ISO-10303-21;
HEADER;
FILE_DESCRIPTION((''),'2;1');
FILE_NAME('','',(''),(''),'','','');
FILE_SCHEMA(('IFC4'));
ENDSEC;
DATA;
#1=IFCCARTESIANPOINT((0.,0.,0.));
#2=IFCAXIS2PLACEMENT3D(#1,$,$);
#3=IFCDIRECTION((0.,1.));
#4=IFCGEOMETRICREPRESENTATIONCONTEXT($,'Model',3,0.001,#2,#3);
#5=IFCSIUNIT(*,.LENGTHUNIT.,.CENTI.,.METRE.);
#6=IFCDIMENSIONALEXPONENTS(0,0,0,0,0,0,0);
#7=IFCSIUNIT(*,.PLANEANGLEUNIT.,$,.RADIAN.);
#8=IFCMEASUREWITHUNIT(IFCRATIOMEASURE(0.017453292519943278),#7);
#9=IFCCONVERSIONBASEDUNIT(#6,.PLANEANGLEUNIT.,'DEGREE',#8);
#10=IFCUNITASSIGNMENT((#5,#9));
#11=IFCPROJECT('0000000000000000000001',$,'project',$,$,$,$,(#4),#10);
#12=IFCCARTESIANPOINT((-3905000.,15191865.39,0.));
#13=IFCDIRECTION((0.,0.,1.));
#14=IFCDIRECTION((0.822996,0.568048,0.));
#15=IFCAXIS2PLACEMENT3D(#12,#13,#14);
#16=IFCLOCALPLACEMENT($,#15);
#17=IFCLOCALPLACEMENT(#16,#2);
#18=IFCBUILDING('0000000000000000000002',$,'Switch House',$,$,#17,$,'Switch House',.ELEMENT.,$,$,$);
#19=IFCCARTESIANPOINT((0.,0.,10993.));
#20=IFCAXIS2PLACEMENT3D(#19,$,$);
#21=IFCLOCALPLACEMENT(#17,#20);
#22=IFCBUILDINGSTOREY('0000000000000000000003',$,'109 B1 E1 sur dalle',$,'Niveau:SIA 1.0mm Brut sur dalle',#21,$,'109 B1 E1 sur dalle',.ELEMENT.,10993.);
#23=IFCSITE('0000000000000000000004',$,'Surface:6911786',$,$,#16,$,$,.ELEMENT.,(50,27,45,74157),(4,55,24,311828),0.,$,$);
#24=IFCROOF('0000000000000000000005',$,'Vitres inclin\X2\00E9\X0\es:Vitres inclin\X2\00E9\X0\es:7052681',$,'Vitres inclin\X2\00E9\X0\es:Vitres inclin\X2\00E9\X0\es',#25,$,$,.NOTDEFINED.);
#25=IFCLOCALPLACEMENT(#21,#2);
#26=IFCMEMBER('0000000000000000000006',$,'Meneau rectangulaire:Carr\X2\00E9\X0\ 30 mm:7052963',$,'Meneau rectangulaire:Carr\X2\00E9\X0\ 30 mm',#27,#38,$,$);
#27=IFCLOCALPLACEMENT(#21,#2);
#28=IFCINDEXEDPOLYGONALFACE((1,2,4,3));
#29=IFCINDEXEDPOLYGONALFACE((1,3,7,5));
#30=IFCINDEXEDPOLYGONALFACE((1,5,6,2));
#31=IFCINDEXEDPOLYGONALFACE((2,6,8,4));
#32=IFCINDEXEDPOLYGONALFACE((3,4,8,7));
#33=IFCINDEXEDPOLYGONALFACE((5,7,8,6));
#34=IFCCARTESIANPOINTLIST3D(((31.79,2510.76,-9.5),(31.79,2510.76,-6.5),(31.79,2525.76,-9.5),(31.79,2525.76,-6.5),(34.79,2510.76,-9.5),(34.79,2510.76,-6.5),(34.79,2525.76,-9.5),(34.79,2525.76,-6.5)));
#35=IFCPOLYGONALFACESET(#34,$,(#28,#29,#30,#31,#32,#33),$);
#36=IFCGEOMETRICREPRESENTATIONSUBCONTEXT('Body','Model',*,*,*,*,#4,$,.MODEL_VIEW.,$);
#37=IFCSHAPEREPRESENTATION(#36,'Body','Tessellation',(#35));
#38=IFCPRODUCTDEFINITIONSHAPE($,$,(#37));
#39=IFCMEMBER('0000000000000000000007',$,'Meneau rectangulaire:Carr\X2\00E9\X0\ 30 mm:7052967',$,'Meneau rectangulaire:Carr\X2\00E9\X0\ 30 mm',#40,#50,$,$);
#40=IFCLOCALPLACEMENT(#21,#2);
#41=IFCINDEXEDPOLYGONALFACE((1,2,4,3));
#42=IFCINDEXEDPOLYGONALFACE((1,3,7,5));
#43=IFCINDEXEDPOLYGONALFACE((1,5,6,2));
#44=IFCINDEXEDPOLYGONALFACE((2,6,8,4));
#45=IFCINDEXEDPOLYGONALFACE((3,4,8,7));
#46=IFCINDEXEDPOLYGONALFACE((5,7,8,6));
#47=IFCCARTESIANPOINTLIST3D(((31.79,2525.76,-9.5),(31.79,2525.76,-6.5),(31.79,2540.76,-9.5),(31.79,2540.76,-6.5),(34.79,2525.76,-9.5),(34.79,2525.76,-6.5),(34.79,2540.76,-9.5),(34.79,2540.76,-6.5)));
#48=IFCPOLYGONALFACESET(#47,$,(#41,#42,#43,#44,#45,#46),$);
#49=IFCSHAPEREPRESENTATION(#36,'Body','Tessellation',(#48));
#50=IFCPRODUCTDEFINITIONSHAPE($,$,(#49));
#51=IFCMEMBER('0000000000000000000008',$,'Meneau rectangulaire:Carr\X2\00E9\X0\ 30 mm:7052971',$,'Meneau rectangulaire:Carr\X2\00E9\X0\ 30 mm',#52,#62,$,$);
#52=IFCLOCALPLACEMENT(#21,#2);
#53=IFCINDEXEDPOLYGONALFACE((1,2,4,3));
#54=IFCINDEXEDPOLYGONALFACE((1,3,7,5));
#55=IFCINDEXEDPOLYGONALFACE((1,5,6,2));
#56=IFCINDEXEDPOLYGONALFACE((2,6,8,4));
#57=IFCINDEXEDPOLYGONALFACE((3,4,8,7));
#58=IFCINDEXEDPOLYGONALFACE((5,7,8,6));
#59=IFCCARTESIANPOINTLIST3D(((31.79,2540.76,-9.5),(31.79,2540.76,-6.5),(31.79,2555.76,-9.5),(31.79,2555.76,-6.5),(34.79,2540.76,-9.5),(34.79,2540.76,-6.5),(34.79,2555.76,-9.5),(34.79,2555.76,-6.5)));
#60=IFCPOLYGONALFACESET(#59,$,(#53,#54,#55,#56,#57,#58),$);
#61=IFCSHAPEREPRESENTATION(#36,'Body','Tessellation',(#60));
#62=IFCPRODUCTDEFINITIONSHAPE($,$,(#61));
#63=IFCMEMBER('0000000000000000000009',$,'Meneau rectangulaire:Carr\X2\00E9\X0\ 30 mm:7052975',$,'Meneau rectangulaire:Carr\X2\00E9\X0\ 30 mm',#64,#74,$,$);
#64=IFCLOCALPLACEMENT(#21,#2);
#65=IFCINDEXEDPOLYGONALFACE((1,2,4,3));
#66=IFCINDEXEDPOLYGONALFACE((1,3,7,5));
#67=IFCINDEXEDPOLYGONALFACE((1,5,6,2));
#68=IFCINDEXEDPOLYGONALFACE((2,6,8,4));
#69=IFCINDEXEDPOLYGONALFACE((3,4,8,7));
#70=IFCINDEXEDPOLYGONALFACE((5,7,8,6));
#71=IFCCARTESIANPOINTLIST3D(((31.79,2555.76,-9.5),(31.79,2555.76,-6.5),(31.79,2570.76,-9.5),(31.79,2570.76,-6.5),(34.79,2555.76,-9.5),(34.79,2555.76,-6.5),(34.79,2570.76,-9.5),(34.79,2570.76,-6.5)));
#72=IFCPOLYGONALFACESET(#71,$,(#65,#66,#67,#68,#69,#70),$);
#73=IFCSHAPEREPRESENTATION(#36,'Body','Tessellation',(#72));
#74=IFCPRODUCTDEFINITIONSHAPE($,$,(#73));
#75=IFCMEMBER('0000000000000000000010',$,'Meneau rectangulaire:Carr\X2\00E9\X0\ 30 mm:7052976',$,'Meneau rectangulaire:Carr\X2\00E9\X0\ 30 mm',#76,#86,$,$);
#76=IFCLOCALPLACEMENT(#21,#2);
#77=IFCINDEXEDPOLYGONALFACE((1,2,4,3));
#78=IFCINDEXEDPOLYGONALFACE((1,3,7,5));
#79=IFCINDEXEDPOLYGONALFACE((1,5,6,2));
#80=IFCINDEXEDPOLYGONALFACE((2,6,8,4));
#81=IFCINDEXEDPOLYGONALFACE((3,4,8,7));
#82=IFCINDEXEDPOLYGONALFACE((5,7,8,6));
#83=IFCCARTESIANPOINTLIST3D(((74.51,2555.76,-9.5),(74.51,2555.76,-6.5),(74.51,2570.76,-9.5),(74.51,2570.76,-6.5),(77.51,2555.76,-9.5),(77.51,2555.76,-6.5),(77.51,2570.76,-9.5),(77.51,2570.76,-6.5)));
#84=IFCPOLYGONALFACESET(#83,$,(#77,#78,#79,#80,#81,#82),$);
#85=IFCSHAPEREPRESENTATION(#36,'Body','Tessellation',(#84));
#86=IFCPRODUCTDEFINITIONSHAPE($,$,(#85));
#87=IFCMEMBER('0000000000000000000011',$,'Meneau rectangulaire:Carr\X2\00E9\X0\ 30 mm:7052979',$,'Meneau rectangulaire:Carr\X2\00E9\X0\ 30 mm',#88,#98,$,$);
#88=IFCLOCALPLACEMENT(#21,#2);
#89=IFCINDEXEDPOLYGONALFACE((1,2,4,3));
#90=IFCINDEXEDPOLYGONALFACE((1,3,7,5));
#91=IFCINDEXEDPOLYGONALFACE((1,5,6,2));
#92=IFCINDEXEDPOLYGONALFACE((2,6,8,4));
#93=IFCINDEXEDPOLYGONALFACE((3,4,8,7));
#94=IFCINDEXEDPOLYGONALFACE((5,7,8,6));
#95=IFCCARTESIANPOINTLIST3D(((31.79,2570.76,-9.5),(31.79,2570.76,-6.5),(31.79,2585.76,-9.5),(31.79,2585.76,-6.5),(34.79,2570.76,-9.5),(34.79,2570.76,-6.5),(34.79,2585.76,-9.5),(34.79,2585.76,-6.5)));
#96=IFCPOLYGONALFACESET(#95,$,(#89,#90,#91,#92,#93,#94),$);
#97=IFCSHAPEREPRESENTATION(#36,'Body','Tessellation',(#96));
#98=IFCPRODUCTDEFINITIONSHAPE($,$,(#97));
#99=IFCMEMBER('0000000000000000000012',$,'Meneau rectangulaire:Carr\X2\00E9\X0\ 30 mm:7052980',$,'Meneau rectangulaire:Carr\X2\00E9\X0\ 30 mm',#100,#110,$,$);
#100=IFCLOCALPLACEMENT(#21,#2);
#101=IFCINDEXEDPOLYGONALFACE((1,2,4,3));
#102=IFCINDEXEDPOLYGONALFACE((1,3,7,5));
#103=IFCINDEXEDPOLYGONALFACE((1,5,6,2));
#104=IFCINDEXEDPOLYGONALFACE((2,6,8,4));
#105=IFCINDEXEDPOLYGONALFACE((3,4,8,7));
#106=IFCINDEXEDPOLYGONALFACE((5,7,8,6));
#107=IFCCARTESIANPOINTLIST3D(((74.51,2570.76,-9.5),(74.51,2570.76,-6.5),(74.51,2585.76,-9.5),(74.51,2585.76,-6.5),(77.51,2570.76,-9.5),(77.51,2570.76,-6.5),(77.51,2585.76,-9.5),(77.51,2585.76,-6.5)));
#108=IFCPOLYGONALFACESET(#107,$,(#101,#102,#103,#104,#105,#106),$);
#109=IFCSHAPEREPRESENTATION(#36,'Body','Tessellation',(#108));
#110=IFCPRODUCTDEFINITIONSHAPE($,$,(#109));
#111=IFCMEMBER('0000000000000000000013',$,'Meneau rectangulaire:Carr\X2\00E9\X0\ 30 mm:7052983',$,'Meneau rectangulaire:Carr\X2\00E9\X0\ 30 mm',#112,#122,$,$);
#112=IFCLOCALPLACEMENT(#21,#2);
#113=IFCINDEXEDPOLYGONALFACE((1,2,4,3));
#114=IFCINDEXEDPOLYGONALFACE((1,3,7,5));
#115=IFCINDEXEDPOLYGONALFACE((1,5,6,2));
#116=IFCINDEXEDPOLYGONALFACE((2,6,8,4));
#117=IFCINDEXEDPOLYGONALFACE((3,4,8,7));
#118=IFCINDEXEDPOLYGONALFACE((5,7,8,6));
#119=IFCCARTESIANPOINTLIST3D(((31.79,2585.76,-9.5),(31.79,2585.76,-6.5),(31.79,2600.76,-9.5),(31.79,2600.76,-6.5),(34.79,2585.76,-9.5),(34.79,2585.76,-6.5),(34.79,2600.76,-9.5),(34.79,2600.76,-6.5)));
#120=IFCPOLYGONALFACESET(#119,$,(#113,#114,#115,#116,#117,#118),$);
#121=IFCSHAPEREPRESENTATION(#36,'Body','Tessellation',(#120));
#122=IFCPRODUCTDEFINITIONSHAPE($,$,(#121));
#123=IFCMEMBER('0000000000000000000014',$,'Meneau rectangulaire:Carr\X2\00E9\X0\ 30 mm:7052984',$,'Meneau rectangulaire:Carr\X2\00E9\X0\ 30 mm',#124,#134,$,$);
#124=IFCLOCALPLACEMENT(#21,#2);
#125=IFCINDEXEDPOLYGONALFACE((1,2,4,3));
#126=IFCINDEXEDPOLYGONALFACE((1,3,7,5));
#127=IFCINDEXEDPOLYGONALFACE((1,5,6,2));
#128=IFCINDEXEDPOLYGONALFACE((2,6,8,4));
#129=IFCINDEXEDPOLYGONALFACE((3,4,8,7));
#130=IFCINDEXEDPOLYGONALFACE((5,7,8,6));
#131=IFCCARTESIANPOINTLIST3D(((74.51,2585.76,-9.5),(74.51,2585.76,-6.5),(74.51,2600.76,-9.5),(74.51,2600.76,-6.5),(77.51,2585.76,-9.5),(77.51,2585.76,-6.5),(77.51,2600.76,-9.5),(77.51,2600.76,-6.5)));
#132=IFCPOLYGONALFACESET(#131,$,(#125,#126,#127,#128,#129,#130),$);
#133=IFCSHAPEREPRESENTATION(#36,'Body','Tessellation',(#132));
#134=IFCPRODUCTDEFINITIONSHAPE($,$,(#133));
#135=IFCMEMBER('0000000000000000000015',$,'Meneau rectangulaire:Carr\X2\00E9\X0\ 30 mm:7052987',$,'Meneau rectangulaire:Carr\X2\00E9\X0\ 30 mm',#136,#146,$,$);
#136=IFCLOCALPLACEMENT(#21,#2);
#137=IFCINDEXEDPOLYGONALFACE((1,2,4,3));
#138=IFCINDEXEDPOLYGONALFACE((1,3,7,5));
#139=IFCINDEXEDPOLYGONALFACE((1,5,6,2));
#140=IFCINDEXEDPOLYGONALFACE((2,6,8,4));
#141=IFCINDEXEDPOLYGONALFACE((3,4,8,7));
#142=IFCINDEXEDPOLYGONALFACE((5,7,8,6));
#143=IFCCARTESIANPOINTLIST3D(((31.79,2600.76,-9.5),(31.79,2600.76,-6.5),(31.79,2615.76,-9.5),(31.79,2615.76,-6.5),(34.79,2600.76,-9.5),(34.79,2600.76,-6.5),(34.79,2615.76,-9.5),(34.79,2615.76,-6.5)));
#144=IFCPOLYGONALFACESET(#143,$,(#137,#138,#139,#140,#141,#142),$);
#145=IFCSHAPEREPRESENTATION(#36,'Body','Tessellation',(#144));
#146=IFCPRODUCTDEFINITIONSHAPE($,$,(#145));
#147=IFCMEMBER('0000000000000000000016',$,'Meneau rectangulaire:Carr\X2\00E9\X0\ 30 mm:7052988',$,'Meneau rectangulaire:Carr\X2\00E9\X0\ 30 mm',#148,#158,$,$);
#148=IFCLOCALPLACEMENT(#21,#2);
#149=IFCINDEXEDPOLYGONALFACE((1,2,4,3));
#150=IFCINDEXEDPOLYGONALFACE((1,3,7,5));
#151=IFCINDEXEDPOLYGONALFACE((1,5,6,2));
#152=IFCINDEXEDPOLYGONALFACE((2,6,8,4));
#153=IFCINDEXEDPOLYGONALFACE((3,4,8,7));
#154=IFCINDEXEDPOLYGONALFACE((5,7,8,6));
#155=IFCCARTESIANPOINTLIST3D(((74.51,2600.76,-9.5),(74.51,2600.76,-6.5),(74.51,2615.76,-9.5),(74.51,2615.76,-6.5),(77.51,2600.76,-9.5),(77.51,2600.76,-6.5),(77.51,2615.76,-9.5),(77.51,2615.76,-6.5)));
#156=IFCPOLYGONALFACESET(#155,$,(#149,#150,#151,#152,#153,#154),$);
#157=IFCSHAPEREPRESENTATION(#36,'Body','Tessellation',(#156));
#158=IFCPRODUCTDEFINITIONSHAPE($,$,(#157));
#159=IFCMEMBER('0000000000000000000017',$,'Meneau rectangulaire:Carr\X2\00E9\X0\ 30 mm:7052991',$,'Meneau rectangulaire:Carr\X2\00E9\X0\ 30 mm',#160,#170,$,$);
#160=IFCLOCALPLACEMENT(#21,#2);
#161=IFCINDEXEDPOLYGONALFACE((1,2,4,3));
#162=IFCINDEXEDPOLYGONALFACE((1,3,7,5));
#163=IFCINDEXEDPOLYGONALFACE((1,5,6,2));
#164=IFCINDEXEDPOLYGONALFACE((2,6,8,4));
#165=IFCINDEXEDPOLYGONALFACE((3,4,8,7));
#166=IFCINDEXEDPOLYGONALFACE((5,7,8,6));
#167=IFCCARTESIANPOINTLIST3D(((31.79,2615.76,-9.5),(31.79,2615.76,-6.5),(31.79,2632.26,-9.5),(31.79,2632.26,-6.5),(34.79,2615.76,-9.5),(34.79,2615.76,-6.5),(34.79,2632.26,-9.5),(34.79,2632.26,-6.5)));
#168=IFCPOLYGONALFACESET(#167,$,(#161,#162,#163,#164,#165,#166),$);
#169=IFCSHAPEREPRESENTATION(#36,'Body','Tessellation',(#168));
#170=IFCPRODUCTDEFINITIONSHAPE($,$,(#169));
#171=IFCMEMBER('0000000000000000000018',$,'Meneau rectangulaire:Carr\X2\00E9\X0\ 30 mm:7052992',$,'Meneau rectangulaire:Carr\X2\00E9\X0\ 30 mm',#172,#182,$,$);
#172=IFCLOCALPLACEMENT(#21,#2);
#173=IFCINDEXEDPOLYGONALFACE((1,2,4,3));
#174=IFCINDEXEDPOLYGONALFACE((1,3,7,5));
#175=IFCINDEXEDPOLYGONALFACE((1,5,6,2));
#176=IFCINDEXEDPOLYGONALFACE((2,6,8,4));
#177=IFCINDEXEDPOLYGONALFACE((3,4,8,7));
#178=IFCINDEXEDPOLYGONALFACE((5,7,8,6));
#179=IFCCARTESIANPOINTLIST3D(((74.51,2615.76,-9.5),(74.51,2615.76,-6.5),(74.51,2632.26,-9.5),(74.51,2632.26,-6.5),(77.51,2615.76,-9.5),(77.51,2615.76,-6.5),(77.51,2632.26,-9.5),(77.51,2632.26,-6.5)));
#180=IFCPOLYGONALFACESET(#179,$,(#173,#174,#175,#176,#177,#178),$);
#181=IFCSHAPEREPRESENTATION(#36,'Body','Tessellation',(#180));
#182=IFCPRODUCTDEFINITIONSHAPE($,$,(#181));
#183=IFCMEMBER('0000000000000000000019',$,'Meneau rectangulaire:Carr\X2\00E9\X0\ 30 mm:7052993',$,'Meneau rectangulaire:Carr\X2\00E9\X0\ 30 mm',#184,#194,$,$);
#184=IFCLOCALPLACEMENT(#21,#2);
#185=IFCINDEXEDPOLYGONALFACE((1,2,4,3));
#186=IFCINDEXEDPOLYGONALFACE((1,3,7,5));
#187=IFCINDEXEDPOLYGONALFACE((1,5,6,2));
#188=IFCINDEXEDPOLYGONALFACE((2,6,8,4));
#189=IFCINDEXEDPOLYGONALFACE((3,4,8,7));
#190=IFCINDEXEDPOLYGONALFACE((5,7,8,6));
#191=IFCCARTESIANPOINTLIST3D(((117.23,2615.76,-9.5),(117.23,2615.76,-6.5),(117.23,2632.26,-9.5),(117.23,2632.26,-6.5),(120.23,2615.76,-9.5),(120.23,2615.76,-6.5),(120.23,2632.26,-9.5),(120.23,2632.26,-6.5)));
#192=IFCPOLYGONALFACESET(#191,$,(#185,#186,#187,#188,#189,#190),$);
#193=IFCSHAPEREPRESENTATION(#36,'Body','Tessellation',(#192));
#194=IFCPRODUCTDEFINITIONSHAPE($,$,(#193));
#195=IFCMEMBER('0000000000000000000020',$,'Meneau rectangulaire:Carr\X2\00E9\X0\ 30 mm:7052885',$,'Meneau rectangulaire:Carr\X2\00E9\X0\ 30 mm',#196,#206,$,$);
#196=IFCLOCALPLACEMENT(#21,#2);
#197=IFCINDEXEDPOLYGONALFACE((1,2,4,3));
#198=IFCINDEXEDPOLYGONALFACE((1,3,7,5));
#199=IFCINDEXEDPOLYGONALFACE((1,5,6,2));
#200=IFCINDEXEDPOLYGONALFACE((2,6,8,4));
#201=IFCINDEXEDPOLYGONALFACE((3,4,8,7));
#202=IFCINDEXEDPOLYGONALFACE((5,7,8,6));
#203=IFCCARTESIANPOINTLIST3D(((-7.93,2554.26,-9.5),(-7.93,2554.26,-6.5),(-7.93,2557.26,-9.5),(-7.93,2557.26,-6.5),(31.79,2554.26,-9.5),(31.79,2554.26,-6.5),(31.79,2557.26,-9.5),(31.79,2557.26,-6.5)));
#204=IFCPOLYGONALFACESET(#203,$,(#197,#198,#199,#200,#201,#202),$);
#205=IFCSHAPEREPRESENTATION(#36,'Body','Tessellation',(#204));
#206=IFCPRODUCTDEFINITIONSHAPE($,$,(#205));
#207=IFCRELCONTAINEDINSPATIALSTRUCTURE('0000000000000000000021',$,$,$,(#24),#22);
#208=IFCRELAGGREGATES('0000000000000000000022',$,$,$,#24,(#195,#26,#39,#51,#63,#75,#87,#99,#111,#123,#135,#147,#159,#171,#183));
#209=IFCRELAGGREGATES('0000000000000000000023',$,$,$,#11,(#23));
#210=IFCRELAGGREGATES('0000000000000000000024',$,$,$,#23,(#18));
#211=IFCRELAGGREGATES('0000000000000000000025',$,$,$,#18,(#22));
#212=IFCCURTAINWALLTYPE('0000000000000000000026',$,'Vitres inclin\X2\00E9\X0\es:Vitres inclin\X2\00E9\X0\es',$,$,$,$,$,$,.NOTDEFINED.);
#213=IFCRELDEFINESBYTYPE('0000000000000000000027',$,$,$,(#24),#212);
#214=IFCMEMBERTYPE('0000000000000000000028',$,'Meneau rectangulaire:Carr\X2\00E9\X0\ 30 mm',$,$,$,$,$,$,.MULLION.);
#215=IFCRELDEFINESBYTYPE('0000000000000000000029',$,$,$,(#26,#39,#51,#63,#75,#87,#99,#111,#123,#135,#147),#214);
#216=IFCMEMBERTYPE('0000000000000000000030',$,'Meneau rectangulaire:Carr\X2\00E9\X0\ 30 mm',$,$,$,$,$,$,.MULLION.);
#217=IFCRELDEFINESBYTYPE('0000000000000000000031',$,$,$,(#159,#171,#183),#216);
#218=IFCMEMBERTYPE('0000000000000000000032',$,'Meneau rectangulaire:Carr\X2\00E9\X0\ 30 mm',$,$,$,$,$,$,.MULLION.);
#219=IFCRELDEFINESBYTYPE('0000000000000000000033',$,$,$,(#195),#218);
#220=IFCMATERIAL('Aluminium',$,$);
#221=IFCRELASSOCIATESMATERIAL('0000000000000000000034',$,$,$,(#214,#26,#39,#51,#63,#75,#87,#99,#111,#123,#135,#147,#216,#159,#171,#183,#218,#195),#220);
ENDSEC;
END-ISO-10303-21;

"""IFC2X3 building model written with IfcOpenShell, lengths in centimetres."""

from ifc_helpers import new_model, entity, si_unit, converted_unit, direction, frame, origin, origin_2d_with_axis, place, context, subcontext, project, spatial, rectangle, extrude, source, transform, mapped, material, type_object, type_shapes, element, aggregate, save


model = new_model("IFC2X3")

# Units and contexts
model_context = context("Model", 3, precision=0.001, world=origin(), true_north=direction((0.0, 1.0)))
body_context = subcontext(model_context, "Body", "Model", "MODEL_VIEW")
ifc_project = project(units=[si_unit("LENGTHUNIT", "METRE", prefix="CENTI"), converted_unit("PLANEANGLEUNIT", "DEGREE", entity("IfcRatioMeasure", 0.017453292519943278), si_unit("PLANEANGLEUNIT", "RADIAN"), dimensions=[0, 0, 0, 0, 0, 0, 0])], contexts=[model_context])

# Site, building, storey
site_placement = place(None, frame((-3905000.0, 15191865.39, 0.0), z_axis=(0.0, 0.0, 1.0), x_axis=(0.822996, 0.568048, 0.0)))
site = spatial("IfcSite", under=ifc_project, at=site_placement, Name="Surface:6911786", CompositionType="ELEMENT", RefLatitude=(50, 27, 45, 74157), RefLongitude=(4, 55, 24, 311828), RefElevation=0.0)
building_placement = place(site_placement, origin())
building = spatial("IfcBuilding", under=site, at=building_placement, Name="Switch House", LongName="Switch House", CompositionType="ELEMENT")
storey_placement = place(building_placement, frame((0.0, 0.0, 10993.0)))
storey = spatial("IfcBuildingStorey", under=building, at=storey_placement, Name="109 B1 E1 sur dalle", ObjectType="Niveau:SIA 1.0mm Brut sur dalle", LongName="109 B1 E1 sur dalle", CompositionType="ELEMENT", Elevation=10993.0)

# Roof, members
curtain_wall_type = type_object("IfcCurtainWallType", Name="Vitres inclinées:Vitres inclinées", PredefinedType="NOTDEFINED")
roof_placement = place(storey_placement, frame((0.0, 0.0, -10993.0)))
roof = element("IfcRoof", 1, at=roof_placement, inside=storey, type_object=curtain_wall_type, Name="Vitres inclinées:Vitres inclinées:7052681", ObjectType="Vitres inclinées:Vitres inclinées", ShapeType="NOTDEFINED")
ifc_material = material(Name="Aluminium")
member_type_1 = type_object("IfcMemberType", Name="Meneau rectangulaire:Carré 30 mm", PredefinedType="MULLION", material=ifc_material)
shared_shape_1 = source(origin(), body_context, "Body", "SweptSolid", [
    extrude(rectangle(XDim=3.0, YDim=3.0, at=origin_2d_with_axis()), frame((0.0, 0.0, -15.0), z_axis=(0.0, 0.0, 1.0), x_axis=(0.0, -1.0, 0.0)), (0.0, 0.0, 1.0), 15.0),
])
type_shapes(member_type_1, [shared_shape_1])
member_1_placement = place(roof_placement, frame((33.29, 2525.76, 10985.0), z_axis=(0.0, 1.0, 0.0), x_axis=(1.0, 0.0, 0.0)))
member_1 = element("IfcMember", 2, at=member_1_placement, type_object=member_type_1, material=ifc_material, Name="Meneau rectangulaire:Carré 30 mm:7052963", ObjectType="Meneau rectangulaire:Carré 30 mm", context=body_context, shape_type="MappedRepresentation", body=[
    mapped(shared_shape_1, transform((0.0, 0.0, 0.0), scale=1.0)),
])
member_2_placement = place(roof_placement, frame((33.29, 2540.76, 10985.0), z_axis=(0.0, 1.0, 0.0), x_axis=(1.0, 0.0, 0.0)))
member_2 = element("IfcMember", 3, at=member_2_placement, type_object=member_type_1, material=ifc_material, Name="Meneau rectangulaire:Carré 30 mm:7052967", ObjectType="Meneau rectangulaire:Carré 30 mm", context=body_context, shape_type="MappedRepresentation", body=[
    mapped(shared_shape_1, transform((0.0, 0.0, 0.0), scale=1.0)),
])
member_3_placement = place(roof_placement, frame((33.29, 2555.76, 10985.0), z_axis=(0.0, 1.0, 0.0), x_axis=(1.0, 0.0, 0.0)))
member_3 = element("IfcMember", 4, at=member_3_placement, type_object=member_type_1, material=ifc_material, Name="Meneau rectangulaire:Carré 30 mm:7052971", ObjectType="Meneau rectangulaire:Carré 30 mm", context=body_context, shape_type="MappedRepresentation", body=[
    mapped(shared_shape_1, transform((0.0, 0.0, 0.0), scale=1.0)),
])
member_4_placement = place(roof_placement, frame((33.29, 2570.76, 10985.0), z_axis=(0.0, 1.0, 0.0), x_axis=(1.0, 0.0, 0.0)))
member_4 = element("IfcMember", 5, at=member_4_placement, type_object=member_type_1, material=ifc_material, Name="Meneau rectangulaire:Carré 30 mm:7052975", ObjectType="Meneau rectangulaire:Carré 30 mm", context=body_context, shape_type="MappedRepresentation", body=[
    mapped(shared_shape_1, transform((0.0, 0.0, 0.0), scale=1.0)),
])
member_5_placement = place(roof_placement, frame((76.01, 2570.76, 10985.0), z_axis=(0.0, 1.0, 0.0), x_axis=(1.0, 0.0, 0.0)))
member_5 = element("IfcMember", 6, at=member_5_placement, type_object=member_type_1, material=ifc_material, Name="Meneau rectangulaire:Carré 30 mm:7052976", ObjectType="Meneau rectangulaire:Carré 30 mm", context=body_context, shape_type="MappedRepresentation", body=[
    mapped(shared_shape_1, transform((0.0, 0.0, 0.0), scale=1.0)),
])
member_6_placement = place(roof_placement, frame((33.29, 2585.76, 10985.0), z_axis=(0.0, 1.0, 0.0), x_axis=(1.0, 0.0, 0.0)))
member_6 = element("IfcMember", 7, at=member_6_placement, type_object=member_type_1, material=ifc_material, Name="Meneau rectangulaire:Carré 30 mm:7052979", ObjectType="Meneau rectangulaire:Carré 30 mm", context=body_context, shape_type="MappedRepresentation", body=[
    mapped(shared_shape_1, transform((0.0, 0.0, 0.0), scale=1.0)),
])
member_7_placement = place(roof_placement, frame((76.01, 2585.76, 10985.0), z_axis=(0.0, 1.0, 0.0), x_axis=(1.0, 0.0, 0.0)))
member_7 = element("IfcMember", 8, at=member_7_placement, type_object=member_type_1, material=ifc_material, Name="Meneau rectangulaire:Carré 30 mm:7052980", ObjectType="Meneau rectangulaire:Carré 30 mm", context=body_context, shape_type="MappedRepresentation", body=[
    mapped(shared_shape_1, transform((0.0, 0.0, 0.0), scale=1.0)),
])
member_8_placement = place(roof_placement, frame((33.29, 2600.76, 10985.0), z_axis=(0.0, 1.0, 0.0), x_axis=(1.0, 0.0, 0.0)))
member_8 = element("IfcMember", 9, at=member_8_placement, type_object=member_type_1, material=ifc_material, Name="Meneau rectangulaire:Carré 30 mm:7052983", ObjectType="Meneau rectangulaire:Carré 30 mm", context=body_context, shape_type="MappedRepresentation", body=[
    mapped(shared_shape_1, transform((0.0, 0.0, 0.0), scale=1.0)),
])
member_9_placement = place(roof_placement, frame((76.01, 2600.76, 10985.0), z_axis=(0.0, 1.0, 0.0), x_axis=(1.0, 0.0, 0.0)))
member_9 = element("IfcMember", 10, at=member_9_placement, type_object=member_type_1, material=ifc_material, Name="Meneau rectangulaire:Carré 30 mm:7052984", ObjectType="Meneau rectangulaire:Carré 30 mm", context=body_context, shape_type="MappedRepresentation", body=[
    mapped(shared_shape_1, transform((0.0, 0.0, 0.0), scale=1.0)),
])
member_10_placement = place(roof_placement, frame((33.29, 2615.76, 10985.0), z_axis=(0.0, 1.0, 0.0), x_axis=(1.0, 0.0, 0.0)))
member_10 = element("IfcMember", 11, at=member_10_placement, type_object=member_type_1, material=ifc_material, Name="Meneau rectangulaire:Carré 30 mm:7052987", ObjectType="Meneau rectangulaire:Carré 30 mm", context=body_context, shape_type="MappedRepresentation", body=[
    mapped(shared_shape_1, transform((0.0, 0.0, 0.0), scale=1.0)),
])
member_11_placement = place(roof_placement, frame((76.01, 2615.76, 10985.0), z_axis=(0.0, 1.0, 0.0), x_axis=(1.0, 0.0, 0.0)))
member_11 = element("IfcMember", 12, at=member_11_placement, type_object=member_type_1, material=ifc_material, Name="Meneau rectangulaire:Carré 30 mm:7052988", ObjectType="Meneau rectangulaire:Carré 30 mm", context=body_context, shape_type="MappedRepresentation", body=[
    mapped(shared_shape_1, transform((0.0, 0.0, 0.0), scale=1.0)),
])
member_type_2 = type_object("IfcMemberType", Name="Meneau rectangulaire:Carré 30 mm", PredefinedType="MULLION", material=ifc_material)
shared_shape_2 = source(origin(), body_context, "Body", "SweptSolid", [
    extrude(rectangle(XDim=3.0, YDim=3.0, at=origin_2d_with_axis()), frame((0.0, 0.0, -16.5), z_axis=(0.0, 0.0, 1.0), x_axis=(0.0, -1.0, 0.0)), (0.0, 0.0, 1.0), 16.5),
])
type_shapes(member_type_2, [shared_shape_2])
member_12_placement = place(roof_placement, frame((33.29, 2632.26, 10985.0), z_axis=(0.0, 1.0, 0.0), x_axis=(1.0, 0.0, 0.0)))
member_12 = element("IfcMember", 13, at=member_12_placement, type_object=member_type_2, material=ifc_material, Name="Meneau rectangulaire:Carré 30 mm:7052991", ObjectType="Meneau rectangulaire:Carré 30 mm", context=body_context, shape_type="MappedRepresentation", body=[
    mapped(shared_shape_2, transform((0.0, 0.0, 0.0), scale=1.0)),
])
member_13_placement = place(roof_placement, frame((76.01, 2632.26, 10985.0), z_axis=(0.0, 1.0, 0.0), x_axis=(1.0, 0.0, 0.0)))
member_13 = element("IfcMember", 14, at=member_13_placement, type_object=member_type_2, material=ifc_material, Name="Meneau rectangulaire:Carré 30 mm:7052992", ObjectType="Meneau rectangulaire:Carré 30 mm", context=body_context, shape_type="MappedRepresentation", body=[
    mapped(shared_shape_2, transform((0.0, 0.0, 0.0), scale=1.0)),
])
member_14_placement = place(roof_placement, frame((118.73, 2632.26, 10985.0), z_axis=(0.0, 1.0, 0.0), x_axis=(1.0, 0.0, 0.0)))
member_14 = element("IfcMember", 15, at=member_14_placement, type_object=member_type_2, material=ifc_material, Name="Meneau rectangulaire:Carré 30 mm:7052993", ObjectType="Meneau rectangulaire:Carré 30 mm", context=body_context, shape_type="MappedRepresentation", body=[
    mapped(shared_shape_2, transform((0.0, 0.0, 0.0), scale=1.0)),
])
member_type_3 = type_object("IfcMemberType", Name="Meneau rectangulaire:Carré 30 mm", PredefinedType="MULLION", material=ifc_material)
shared_shape_3 = source(origin(), body_context, "Body", "SweptSolid", [
    extrude(rectangle(XDim=3.0, YDim=3.0, at=origin_2d_with_axis()), frame((0.0, 0.0, -39.72), z_axis=(0.0, 0.0, 1.0), x_axis=(0.0, -1.0, 0.0)), (0.0, 0.0, 1.0), 39.72),
])
type_shapes(member_type_3, [shared_shape_3])
member_15_placement = place(roof_placement, frame((-7.93, 2555.76, 10985.0), z_axis=(-1.0, 0.0, 0.0), x_axis=(0.0, 1.0, 0.0)))
member_15 = element("IfcMember", 16, at=member_15_placement, type_object=member_type_3, material=ifc_material, Name="Meneau rectangulaire:Carré 30 mm:7052885", ObjectType="Meneau rectangulaire:Carré 30 mm", context=body_context, shape_type="MappedRepresentation", body=[
    mapped(shared_shape_3, transform((0.0, 0.0, 0.0), scale=1.0)),
])
aggregate(roof, [member_15, member_1, member_2, member_3, member_4, member_5, member_6, member_7, member_8, member_9, member_10, member_11, member_12, member_13, member_14])

save(model, "model.ifc")
